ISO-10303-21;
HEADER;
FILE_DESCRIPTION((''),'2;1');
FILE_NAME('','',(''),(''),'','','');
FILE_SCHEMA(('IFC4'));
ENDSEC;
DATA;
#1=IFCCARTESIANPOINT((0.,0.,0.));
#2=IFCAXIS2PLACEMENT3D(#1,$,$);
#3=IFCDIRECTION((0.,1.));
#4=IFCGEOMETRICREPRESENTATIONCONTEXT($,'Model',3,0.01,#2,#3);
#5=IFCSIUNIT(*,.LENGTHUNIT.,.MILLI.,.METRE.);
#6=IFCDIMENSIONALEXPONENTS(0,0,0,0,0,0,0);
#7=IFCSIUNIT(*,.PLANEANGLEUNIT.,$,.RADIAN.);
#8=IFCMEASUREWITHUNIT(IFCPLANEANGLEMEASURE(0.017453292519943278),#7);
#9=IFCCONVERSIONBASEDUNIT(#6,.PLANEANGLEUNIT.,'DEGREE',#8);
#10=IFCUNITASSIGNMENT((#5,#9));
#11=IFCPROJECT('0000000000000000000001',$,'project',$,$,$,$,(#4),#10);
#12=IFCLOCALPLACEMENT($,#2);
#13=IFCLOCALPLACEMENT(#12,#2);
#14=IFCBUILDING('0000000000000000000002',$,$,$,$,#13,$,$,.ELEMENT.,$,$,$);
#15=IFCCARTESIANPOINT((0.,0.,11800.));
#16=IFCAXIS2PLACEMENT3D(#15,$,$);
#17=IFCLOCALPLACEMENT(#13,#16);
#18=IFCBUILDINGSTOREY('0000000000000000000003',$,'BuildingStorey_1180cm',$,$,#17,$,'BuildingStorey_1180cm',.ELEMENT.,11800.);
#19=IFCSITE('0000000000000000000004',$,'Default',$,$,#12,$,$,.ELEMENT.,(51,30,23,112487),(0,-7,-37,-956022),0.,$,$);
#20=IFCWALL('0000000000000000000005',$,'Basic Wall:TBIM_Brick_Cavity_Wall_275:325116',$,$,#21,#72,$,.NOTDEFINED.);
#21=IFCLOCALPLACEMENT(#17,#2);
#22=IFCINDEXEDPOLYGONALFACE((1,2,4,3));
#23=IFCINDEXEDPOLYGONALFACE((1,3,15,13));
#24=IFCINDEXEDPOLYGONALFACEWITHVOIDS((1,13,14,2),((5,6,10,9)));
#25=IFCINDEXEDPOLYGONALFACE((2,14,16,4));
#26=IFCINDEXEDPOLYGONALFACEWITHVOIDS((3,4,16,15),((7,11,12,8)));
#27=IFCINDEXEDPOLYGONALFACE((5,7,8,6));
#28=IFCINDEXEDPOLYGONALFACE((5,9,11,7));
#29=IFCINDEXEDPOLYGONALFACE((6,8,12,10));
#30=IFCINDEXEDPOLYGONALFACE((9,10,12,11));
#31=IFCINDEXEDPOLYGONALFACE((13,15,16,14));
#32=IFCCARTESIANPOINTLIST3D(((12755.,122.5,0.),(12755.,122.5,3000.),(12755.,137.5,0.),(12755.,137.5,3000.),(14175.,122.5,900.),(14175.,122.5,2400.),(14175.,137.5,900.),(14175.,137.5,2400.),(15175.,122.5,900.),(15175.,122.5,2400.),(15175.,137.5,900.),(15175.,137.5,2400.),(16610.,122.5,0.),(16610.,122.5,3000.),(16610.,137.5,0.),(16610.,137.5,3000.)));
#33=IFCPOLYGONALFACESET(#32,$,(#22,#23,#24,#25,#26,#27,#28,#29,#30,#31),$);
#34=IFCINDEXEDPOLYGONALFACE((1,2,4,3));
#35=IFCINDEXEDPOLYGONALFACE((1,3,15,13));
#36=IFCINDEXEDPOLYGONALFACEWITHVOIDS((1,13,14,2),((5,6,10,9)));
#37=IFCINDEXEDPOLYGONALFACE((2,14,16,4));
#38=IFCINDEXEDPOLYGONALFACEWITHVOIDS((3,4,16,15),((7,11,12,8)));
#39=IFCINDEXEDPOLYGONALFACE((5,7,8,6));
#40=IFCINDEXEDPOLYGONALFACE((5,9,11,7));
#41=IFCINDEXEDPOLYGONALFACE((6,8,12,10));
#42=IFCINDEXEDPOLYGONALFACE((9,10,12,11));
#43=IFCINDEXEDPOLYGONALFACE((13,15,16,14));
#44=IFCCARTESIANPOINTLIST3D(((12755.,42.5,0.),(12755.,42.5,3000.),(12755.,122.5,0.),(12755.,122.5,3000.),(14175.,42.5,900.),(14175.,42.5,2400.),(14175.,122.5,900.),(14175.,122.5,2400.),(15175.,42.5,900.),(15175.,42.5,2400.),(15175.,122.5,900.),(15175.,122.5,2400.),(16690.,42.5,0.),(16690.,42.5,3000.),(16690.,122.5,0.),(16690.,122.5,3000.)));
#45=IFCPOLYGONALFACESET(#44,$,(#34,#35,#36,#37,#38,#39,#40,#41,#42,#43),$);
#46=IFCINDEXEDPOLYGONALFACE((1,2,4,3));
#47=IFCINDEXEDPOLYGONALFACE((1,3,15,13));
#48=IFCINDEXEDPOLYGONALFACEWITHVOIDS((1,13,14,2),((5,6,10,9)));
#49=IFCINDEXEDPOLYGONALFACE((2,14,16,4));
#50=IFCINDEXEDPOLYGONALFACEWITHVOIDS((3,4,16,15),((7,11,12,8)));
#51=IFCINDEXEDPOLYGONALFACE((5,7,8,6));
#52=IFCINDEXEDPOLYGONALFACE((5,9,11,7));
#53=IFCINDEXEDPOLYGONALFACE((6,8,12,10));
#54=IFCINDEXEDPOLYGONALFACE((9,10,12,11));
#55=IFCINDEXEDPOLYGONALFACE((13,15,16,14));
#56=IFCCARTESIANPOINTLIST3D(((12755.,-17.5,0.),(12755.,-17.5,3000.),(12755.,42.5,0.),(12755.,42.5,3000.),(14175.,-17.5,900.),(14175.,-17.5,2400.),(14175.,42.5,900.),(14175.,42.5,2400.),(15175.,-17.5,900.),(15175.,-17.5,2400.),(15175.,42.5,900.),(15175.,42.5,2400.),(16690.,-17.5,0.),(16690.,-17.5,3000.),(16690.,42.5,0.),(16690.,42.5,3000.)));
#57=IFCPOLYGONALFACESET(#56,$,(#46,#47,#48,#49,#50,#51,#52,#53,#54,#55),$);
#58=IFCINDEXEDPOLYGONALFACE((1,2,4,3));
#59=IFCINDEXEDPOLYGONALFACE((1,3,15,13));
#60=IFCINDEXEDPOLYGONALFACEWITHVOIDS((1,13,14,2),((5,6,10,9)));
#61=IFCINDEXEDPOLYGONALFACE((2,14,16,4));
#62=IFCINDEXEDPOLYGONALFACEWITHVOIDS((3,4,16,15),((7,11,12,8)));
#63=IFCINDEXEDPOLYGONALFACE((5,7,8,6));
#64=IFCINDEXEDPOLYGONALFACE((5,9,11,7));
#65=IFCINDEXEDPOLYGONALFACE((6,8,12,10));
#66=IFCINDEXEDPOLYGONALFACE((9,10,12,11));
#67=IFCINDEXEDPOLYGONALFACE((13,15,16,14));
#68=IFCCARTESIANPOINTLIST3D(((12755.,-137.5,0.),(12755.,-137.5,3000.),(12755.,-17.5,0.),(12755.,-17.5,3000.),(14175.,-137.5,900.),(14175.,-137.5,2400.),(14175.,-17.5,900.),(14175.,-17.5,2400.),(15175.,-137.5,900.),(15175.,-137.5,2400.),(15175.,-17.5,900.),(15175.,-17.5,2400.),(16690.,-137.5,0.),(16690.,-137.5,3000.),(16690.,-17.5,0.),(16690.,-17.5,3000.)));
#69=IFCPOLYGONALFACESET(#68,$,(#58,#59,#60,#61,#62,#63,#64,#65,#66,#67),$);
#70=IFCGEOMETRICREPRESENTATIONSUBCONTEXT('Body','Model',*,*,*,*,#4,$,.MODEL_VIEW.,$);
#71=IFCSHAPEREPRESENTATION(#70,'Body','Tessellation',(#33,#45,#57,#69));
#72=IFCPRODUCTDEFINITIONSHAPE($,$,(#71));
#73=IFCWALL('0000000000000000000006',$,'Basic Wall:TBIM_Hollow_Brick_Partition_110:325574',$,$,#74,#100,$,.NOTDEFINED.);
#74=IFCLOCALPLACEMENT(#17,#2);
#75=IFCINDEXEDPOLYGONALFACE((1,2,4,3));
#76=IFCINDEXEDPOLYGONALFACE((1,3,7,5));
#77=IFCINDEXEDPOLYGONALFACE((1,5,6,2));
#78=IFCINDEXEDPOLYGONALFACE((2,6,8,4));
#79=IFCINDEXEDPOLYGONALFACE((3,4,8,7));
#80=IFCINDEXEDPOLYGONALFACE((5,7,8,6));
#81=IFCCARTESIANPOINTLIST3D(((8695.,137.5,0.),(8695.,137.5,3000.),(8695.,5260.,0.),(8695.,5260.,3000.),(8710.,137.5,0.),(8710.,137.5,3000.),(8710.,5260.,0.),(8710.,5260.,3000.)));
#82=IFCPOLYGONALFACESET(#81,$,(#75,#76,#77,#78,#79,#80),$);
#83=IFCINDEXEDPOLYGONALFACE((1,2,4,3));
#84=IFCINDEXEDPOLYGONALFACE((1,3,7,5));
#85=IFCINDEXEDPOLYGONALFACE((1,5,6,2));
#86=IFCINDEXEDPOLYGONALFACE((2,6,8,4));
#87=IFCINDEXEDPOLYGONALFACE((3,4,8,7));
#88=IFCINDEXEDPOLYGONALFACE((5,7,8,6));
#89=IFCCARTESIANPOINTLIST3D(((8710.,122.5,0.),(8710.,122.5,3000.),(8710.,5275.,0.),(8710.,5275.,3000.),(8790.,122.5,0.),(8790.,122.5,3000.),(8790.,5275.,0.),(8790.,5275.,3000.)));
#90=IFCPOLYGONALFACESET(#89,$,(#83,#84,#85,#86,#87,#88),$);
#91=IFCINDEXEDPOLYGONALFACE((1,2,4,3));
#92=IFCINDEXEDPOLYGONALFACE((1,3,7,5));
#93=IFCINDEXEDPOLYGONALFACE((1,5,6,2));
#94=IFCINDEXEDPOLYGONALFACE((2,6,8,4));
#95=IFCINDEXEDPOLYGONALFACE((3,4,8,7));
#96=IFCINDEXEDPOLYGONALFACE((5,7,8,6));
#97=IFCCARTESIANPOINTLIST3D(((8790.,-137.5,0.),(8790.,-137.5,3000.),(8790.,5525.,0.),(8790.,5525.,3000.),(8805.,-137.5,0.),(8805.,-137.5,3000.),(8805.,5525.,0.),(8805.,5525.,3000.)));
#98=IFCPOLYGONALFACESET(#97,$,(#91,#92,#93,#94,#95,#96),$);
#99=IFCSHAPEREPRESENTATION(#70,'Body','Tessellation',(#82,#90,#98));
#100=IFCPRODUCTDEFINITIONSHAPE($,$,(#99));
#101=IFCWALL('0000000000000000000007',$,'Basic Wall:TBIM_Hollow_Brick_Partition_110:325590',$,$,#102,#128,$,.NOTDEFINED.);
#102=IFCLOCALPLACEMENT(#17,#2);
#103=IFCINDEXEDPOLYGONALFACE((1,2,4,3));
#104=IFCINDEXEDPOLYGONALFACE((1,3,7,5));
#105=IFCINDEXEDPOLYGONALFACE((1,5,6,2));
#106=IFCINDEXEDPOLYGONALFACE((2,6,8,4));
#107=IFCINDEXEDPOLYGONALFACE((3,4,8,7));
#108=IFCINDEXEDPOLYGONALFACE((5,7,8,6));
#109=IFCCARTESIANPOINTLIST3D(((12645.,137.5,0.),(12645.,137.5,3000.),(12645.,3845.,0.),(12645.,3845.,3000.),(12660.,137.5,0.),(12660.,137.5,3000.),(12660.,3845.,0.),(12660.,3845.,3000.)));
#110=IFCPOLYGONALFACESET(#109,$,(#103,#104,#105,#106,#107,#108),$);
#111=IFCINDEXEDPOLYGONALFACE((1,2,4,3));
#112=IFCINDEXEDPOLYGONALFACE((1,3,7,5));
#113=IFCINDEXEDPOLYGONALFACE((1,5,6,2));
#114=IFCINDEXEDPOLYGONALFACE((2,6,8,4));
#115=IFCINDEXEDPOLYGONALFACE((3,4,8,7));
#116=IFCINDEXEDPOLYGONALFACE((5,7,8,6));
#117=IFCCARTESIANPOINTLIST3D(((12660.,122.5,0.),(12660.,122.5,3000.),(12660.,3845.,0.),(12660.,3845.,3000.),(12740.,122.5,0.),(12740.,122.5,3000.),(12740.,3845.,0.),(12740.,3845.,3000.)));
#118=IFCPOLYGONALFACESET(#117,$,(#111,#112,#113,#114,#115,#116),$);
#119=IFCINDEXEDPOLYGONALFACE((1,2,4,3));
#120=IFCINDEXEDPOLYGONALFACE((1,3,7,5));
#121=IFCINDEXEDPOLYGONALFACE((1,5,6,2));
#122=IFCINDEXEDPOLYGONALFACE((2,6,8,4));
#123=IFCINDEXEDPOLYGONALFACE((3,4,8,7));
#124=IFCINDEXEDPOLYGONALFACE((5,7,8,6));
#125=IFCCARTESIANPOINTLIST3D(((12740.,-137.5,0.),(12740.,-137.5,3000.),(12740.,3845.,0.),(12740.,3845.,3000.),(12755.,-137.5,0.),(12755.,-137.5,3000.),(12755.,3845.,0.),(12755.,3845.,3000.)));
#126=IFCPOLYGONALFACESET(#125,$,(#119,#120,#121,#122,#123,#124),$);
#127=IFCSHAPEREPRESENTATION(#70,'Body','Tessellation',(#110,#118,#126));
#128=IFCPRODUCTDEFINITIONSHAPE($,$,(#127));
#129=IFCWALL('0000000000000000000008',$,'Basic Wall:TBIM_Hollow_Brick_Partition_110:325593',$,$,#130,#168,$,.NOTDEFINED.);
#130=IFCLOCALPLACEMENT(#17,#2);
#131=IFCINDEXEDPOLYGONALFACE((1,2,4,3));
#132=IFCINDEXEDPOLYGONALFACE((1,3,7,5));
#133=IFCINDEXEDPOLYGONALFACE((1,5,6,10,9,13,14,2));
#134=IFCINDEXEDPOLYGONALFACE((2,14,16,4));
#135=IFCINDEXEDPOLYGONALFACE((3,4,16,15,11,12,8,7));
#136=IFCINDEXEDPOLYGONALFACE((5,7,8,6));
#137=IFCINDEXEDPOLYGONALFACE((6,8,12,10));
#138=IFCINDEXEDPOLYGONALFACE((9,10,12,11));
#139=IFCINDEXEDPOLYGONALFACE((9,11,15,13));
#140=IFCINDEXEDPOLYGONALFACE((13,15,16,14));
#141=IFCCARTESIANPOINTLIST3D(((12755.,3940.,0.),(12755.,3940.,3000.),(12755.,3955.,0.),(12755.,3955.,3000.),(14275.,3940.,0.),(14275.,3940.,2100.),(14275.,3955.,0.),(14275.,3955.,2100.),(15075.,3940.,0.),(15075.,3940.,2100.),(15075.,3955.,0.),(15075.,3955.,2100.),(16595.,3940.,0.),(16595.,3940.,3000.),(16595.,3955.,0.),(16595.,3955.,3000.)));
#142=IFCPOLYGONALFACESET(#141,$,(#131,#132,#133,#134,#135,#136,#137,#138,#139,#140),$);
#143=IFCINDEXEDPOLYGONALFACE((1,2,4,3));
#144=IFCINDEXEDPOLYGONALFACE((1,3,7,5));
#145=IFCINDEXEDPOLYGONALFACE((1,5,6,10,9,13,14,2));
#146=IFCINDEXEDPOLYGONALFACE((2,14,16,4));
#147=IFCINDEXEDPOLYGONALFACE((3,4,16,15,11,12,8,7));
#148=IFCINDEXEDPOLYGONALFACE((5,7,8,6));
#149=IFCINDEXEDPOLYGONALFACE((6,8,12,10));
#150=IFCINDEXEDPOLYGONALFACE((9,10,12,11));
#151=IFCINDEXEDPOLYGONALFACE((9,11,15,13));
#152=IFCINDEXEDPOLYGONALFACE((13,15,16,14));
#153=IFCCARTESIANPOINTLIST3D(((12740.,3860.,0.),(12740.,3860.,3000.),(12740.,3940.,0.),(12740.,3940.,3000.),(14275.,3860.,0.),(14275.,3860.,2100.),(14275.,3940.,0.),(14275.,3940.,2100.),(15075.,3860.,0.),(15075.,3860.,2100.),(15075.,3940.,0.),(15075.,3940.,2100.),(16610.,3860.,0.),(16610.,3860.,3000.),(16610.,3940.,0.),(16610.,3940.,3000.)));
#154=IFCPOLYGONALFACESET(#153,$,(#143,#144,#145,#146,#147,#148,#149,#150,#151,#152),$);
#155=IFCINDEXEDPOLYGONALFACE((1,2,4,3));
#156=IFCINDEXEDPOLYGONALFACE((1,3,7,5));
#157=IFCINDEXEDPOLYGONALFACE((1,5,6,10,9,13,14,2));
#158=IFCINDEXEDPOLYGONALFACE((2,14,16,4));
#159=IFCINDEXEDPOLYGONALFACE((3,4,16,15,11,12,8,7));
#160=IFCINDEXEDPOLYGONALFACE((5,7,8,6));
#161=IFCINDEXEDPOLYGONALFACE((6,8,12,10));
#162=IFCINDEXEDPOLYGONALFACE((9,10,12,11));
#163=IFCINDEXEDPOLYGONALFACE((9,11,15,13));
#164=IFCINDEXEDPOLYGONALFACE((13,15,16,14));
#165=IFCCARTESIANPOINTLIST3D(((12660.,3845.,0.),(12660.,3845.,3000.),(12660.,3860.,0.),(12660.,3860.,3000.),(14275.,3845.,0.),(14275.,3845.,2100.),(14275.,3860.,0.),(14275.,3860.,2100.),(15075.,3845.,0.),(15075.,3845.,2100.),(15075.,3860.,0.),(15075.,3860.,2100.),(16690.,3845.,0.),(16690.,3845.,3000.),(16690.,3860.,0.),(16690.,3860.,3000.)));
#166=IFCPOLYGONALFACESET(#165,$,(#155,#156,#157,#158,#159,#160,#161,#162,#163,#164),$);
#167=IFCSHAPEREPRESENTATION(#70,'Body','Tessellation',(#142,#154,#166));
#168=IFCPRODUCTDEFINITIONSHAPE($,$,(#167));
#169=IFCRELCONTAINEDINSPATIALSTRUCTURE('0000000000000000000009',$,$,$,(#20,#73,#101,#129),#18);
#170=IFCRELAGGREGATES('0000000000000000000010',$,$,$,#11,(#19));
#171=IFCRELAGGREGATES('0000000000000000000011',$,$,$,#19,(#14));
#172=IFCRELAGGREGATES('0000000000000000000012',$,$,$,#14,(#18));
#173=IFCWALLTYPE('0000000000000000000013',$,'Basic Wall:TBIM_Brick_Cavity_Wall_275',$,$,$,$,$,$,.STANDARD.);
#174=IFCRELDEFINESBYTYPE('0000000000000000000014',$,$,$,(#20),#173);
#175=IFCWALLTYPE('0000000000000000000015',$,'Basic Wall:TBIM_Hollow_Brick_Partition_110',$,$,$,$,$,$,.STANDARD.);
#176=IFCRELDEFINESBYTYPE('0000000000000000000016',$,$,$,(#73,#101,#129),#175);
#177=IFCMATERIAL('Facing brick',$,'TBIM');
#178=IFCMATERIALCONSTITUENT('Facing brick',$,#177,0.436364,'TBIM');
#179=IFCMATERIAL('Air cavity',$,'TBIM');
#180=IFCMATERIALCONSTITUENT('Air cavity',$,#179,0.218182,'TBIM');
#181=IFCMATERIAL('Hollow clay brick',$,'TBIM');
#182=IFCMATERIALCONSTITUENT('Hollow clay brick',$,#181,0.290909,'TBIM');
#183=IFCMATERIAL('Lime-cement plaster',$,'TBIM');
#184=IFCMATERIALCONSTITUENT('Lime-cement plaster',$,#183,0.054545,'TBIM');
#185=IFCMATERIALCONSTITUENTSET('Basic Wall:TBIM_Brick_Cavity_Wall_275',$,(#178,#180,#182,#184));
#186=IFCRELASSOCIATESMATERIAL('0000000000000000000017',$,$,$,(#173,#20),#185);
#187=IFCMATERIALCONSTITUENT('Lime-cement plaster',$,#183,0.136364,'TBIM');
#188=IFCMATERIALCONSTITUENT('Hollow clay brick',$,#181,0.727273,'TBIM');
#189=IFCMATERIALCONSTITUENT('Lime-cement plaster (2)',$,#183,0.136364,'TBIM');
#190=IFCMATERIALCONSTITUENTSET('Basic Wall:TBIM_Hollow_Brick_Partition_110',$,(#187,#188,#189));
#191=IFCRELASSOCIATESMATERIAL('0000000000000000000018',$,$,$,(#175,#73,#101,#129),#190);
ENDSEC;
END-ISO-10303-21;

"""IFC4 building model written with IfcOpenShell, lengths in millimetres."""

from ifc_helpers import new_model, entity, si_unit, converted_unit, direction, frame, origin, place, context, subcontext, project, spatial, indexed_curve, outline, extrude, material, constituent, constituent_set, type_object, element, save


model = new_model("IFC4")

# Units and contexts
model_context = context("Model", 3, precision=0.01, world=origin(), true_north=direction((0.0, 1.0)))
body_context = subcontext(model_context, "Body", "Model", "MODEL_VIEW")
ifc_project = project(units=[si_unit("LENGTHUNIT", "METRE", prefix="MILLI"), converted_unit("PLANEANGLEUNIT", "DEGREE", entity("IfcPlaneAngleMeasure", 0.017453292519943278), si_unit("PLANEANGLEUNIT", "RADIAN"), dimensions=[0, 0, 0, 0, 0, 0, 0])], contexts=[model_context])

# Site, building, storey
site_placement = place(None, origin())
site = spatial("IfcSite", under=ifc_project, at=site_placement, Name="Default", CompositionType="ELEMENT", RefLatitude=(51, 30, 23, 112487), RefLongitude=(0, -7, -37, -956022), RefElevation=0.0)
building_placement = place(site_placement, origin())
building = spatial("IfcBuilding", under=site, at=building_placement, CompositionType="ELEMENT")
storey_placement = place(building_placement, frame((0.0, 0.0, 11800.0)))
storey = spatial("IfcBuildingStorey", under=building, at=storey_placement, Name="BuildingStorey_1180cm", LongName="BuildingStorey_1180cm", CompositionType="ELEMENT", Elevation=11800.0)

# Wall, opening
ifc_material_1 = material(Name="Facing brick", Category="TBIM")
ifc_constituent_1 = constituent(ifc_material_1, Name="Facing brick", Category="TBIM", fraction=0.436364)
ifc_material_2 = material(Name="Air cavity", Category="TBIM")
ifc_constituent_2 = constituent(ifc_material_2, Name="Air cavity", Category="TBIM", fraction=0.218182)
ifc_material_3 = material(Name="Hollow clay brick", Category="TBIM")
ifc_constituent_3 = constituent(ifc_material_3, Name="Hollow clay brick", Category="TBIM", fraction=0.290909)
ifc_material_4 = material(Name="Lime-cement plaster", Category="TBIM")
ifc_constituent_4 = constituent(ifc_material_4, Name="Lime-cement plaster", Category="TBIM", fraction=0.054545)
ifc_constituent_set_1 = constituent_set(constituents=[ifc_constituent_1, ifc_constituent_2, ifc_constituent_3, ifc_constituent_4], Name="Basic Wall:TBIM_Brick_Cavity_Wall_275")
wall_type_1 = type_object("IfcWallType", Name="Basic Wall:TBIM_Brick_Cavity_Wall_275", PredefinedType="STANDARD", material=ifc_constituent_set_1)
wall_1_placement = place(storey_placement, frame((12755.0, 0.0, 0.0)))
wall_1 = element("IfcWall", 1, at=wall_1_placement, inside=storey, type_object=wall_type_1, material=ifc_constituent_set_1, Name="Basic Wall:TBIM_Brick_Cavity_Wall_275:325116", PredefinedType="NOTDEFINED", context=body_context, shape_type="SweptSolid", body=[
    extrude(outline(indexed_curve([(-1500.0, -1927.5), (1500.0, -1927.5), (1500.0, 1927.5), (-1500.0, 1927.5), (-1500.0, -1927.5)], self_intersect=False), holes=[indexed_curve([(-600.0, -507.5), (-600.0, 492.5), (900.0, 492.5), (900.0, -507.5), (-600.0, -507.5)], self_intersect=False)]), frame((1927.5, 122.5, 1500.0), z_axis=(0.0, 1.0, 0.0), x_axis=(0.0, 0.0, 1.0)), (0.0, 0.0, 1.0), 15.0),
    extrude(outline(indexed_curve([(-1500.0, -1967.5), (1500.0, -1967.5), (1500.0, 1967.5), (-1500.0, 1967.5), (-1500.0, -1967.5)], self_intersect=False), holes=[indexed_curve([(-600.0, -547.5), (-600.0, 452.5), (900.0, 452.5), (900.0, -547.5), (-600.0, -547.5)], self_intersect=False)]), frame((1967.5, 42.5, 1500.0), z_axis=(0.0, 1.0, 0.0), x_axis=(0.0, 0.0, 1.0)), (0.0, 0.0, 1.0), 80.0),
    extrude(outline(indexed_curve([(-1500.0, -1967.5), (1500.0, -1967.5), (1500.0, 1967.5), (-1500.0, 1967.5), (-1500.0, -1967.5)], self_intersect=False), holes=[indexed_curve([(-600.0, -547.5), (-600.0, 452.5), (900.0, 452.5), (900.0, -547.5), (-600.0, -547.5)], self_intersect=False)]), frame((1967.5, -17.5, 1500.0), z_axis=(0.0, 1.0, 0.0), x_axis=(0.0, 0.0, 1.0)), (0.0, 0.0, 1.0), 60.0),
    extrude(outline(indexed_curve([(-1500.0, -1967.5), (1500.0, -1967.5), (1500.0, 1967.5), (-1500.0, 1967.5), (-1500.0, -1967.5)], self_intersect=False), holes=[indexed_curve([(900.0, -547.5), (-600.0, -547.5), (-600.0, 452.5), (900.0, 452.5), (900.0, -547.5)], self_intersect=False)]), frame((1967.5, -137.5, 1500.0), z_axis=(0.0, 1.0, 0.0), x_axis=(0.0, 0.0, 1.0)), (0.0, 0.0, 1.0), 120.0),
])
opening_1_placement = place(wall_1_placement, frame((1420.0, -137.5, 900.0)))
element("IfcOpeningElement", 2, at=opening_1_placement, cuts=wall_1, PredefinedType="OPENING", context=body_context, shape_type="SweptSolid", body=[
    extrude(outline(indexed_curve([(1500.0, 0.0), (1500.0, 1000.0), (0.0, 1000.0), (0.0, 0.0), (1500.0, 0.0)], self_intersect=False)), frame((0.0, 0.0, 0.0), z_axis=(0.0, 1.0, 0.0), x_axis=(0.0, 0.0, 1.0)), (0.0, 0.0, 1.0), 275.0),
])
ifc_constituent_5 = constituent(ifc_material_4, Name="Lime-cement plaster", Category="TBIM", fraction=0.136364)
ifc_constituent_6 = constituent(ifc_material_3, Name="Hollow clay brick", Category="TBIM", fraction=0.727273)
ifc_constituent_7 = constituent(ifc_material_4, Name="Lime-cement plaster (2)", Category="TBIM", fraction=0.136364)
ifc_constituent_set_2 = constituent_set(constituents=[ifc_constituent_5, ifc_constituent_6, ifc_constituent_7], Name="Basic Wall:TBIM_Hollow_Brick_Partition_110")
wall_type_2 = type_object("IfcWallType", Name="Basic Wall:TBIM_Hollow_Brick_Partition_110", PredefinedType="STANDARD", material=ifc_constituent_set_2)

# Wall
wall_2_placement = place(storey_placement, frame((8750.0, 137.5, 0.0), z_axis=(0.0, 0.0, 1.0), x_axis=(0.0, 1.0, 0.0)))
element("IfcWall", 3, at=wall_2_placement, inside=storey, type_object=wall_type_2, material=ifc_constituent_set_2, Name="Basic Wall:TBIM_Hollow_Brick_Partition_110:325574", PredefinedType="NOTDEFINED", context=body_context, shape_type="SweptSolid", body=[
    extrude(outline(indexed_curve([(-7.5, -2561.3), (7.5, -2561.3), (7.5, 2561.3), (-7.5, 2561.3), (-7.5, -2561.3)], self_intersect=False)), frame((2561.3, 47.5, 0.0), z_axis=(0.0, 0.0, 1.0), x_axis=(0.0, -1.0, 0.0)), (0.0, 0.0, 1.0), 3000.0),
    extrude(outline(indexed_curve([(-2576.3, -40.0), (2576.3, -40.0), (2576.3, 40.0), (-2576.3, 40.0), (-2576.3, -40.0)], self_intersect=False)), frame((2561.3, 0.0, 0.0)), (0.0, 0.0, 1.0), 3000.0),
    extrude(outline(indexed_curve([(-7.5, -2831.3), (7.5, -2831.3), (7.5, 2831.3), (-7.5, 2831.3), (-7.5, -2831.3)], self_intersect=False)), frame((2556.3, -47.5, 0.0), z_axis=(0.0, 0.0, 1.0), x_axis=(0.0, 1.0, 0.0)), (0.0, 0.0, 1.0), 3000.0),
])

# Wall
wall_3_placement = place(storey_placement, frame((12700.0, 137.5, 0.0), z_axis=(0.0, 0.0, 1.0), x_axis=(0.0, 1.0, 0.0)))
element("IfcWall", 4, at=wall_3_placement, inside=storey, type_object=wall_type_2, material=ifc_constituent_set_2, Name="Basic Wall:TBIM_Hollow_Brick_Partition_110:325590", PredefinedType="NOTDEFINED", context=body_context, shape_type="SweptSolid", body=[
    extrude(outline(indexed_curve([(-7.5, -1853.8), (7.5, -1853.8), (7.5, 1853.8), (-7.5, 1853.8), (-7.5, -1853.8)], self_intersect=False)), frame((1853.8, 47.5, 0.0), z_axis=(0.0, 0.0, 1.0), x_axis=(0.0, -1.0, 0.0)), (0.0, 0.0, 1.0), 3000.0),
    extrude(outline(indexed_curve([(-1861.3, -40.0), (1861.3, -40.0), (1861.3, 40.0), (-1861.3, 40.0), (-1861.3, -40.0)], self_intersect=False)), frame((1846.3, 0.0, 0.0)), (0.0, 0.0, 1.0), 3000.0),
    extrude(outline(indexed_curve([(-7.5, -1991.3), (7.5, -1991.3), (7.5, 1991.3), (-7.5, 1991.3), (-7.5, -1991.3)], self_intersect=False)), frame((1716.3, -47.5, 0.0), z_axis=(0.0, 0.0, 1.0), x_axis=(0.0, 1.0, 0.0)), (0.0, 0.0, 1.0), 3000.0),
])

# Wall, opening
wall_4_placement = place(storey_placement, frame((12755.0, 3900.0, 0.0)))
wall_4 = element("IfcWall", 5, at=wall_4_placement, inside=storey, type_object=wall_type_2, material=ifc_constituent_set_2, Name="Basic Wall:TBIM_Hollow_Brick_Partition_110:325593", PredefinedType="NOTDEFINED", context=body_context, shape_type="SweptSolid", body=[
    extrude(outline(indexed_curve([(-1275.0, -1920.0), (1725.0, -1920.0), (1725.0, 1920.0), (-1275.0, 1920.0), (-1275.0, 400.0), (825.0, 400.0), (825.0, -400.0), (-1275.0, -400.0), (-1275.0, -1920.0)], self_intersect=False)), frame((1920.0, 40.0, 1275.0), z_axis=(0.0, 1.0, 0.0), x_axis=(0.0, 0.0, 1.0)), (0.0, 0.0, 1.0), 15.0),
    extrude(outline(indexed_curve([(-1275.0, -1935.0), (1725.0, -1935.0), (1725.0, 1935.0), (-1275.0, 1935.0), (-1275.0, 400.0), (825.0, 400.0), (825.0, -400.0), (-1275.0, -400.0), (-1275.0, -1935.0)], self_intersect=False)), frame((1920.0, -40.0, 1275.0), z_axis=(0.0, 1.0, 0.0), x_axis=(0.0, 0.0, 1.0)), (0.0, 0.0, 1.0), 80.0),
    extrude(outline(indexed_curve([(-1725.0, -2015.0), (1275.0, -2015.0), (1275.0, -400.0), (-825.0, -400.0), (-825.0, 400.0), (1275.0, 400.0), (1275.0, 2015.0), (-1725.0, 2015.0), (-1725.0, -2015.0)], self_intersect=False)), frame((1920.0, -55.0, 1275.0), z_axis=(0.0, 1.0, 0.0), x_axis=(0.0, 0.0, -1.0)), (0.0, 0.0, 1.0), 15.0),
])
opening_2_placement = place(wall_4_placement, frame((1520.0, -55.0, 0.0)))
element("IfcOpeningElement", 6, at=opening_2_placement, cuts=wall_4, PredefinedType="OPENING", context=body_context, shape_type="SweptSolid", body=[
    extrude(outline(indexed_curve([(0.0, 800.0), (0.0, 0.0), (2100.0, 0.0), (2100.0, 800.0), (0.0, 800.0)], self_intersect=False)), frame((0.0, 0.0, 0.0), z_axis=(0.0, 1.0, 0.0), x_axis=(0.0, 0.0, 1.0)), (0.0, 0.0, 1.0), 110.0),
])

save(model, "model.ifc")
